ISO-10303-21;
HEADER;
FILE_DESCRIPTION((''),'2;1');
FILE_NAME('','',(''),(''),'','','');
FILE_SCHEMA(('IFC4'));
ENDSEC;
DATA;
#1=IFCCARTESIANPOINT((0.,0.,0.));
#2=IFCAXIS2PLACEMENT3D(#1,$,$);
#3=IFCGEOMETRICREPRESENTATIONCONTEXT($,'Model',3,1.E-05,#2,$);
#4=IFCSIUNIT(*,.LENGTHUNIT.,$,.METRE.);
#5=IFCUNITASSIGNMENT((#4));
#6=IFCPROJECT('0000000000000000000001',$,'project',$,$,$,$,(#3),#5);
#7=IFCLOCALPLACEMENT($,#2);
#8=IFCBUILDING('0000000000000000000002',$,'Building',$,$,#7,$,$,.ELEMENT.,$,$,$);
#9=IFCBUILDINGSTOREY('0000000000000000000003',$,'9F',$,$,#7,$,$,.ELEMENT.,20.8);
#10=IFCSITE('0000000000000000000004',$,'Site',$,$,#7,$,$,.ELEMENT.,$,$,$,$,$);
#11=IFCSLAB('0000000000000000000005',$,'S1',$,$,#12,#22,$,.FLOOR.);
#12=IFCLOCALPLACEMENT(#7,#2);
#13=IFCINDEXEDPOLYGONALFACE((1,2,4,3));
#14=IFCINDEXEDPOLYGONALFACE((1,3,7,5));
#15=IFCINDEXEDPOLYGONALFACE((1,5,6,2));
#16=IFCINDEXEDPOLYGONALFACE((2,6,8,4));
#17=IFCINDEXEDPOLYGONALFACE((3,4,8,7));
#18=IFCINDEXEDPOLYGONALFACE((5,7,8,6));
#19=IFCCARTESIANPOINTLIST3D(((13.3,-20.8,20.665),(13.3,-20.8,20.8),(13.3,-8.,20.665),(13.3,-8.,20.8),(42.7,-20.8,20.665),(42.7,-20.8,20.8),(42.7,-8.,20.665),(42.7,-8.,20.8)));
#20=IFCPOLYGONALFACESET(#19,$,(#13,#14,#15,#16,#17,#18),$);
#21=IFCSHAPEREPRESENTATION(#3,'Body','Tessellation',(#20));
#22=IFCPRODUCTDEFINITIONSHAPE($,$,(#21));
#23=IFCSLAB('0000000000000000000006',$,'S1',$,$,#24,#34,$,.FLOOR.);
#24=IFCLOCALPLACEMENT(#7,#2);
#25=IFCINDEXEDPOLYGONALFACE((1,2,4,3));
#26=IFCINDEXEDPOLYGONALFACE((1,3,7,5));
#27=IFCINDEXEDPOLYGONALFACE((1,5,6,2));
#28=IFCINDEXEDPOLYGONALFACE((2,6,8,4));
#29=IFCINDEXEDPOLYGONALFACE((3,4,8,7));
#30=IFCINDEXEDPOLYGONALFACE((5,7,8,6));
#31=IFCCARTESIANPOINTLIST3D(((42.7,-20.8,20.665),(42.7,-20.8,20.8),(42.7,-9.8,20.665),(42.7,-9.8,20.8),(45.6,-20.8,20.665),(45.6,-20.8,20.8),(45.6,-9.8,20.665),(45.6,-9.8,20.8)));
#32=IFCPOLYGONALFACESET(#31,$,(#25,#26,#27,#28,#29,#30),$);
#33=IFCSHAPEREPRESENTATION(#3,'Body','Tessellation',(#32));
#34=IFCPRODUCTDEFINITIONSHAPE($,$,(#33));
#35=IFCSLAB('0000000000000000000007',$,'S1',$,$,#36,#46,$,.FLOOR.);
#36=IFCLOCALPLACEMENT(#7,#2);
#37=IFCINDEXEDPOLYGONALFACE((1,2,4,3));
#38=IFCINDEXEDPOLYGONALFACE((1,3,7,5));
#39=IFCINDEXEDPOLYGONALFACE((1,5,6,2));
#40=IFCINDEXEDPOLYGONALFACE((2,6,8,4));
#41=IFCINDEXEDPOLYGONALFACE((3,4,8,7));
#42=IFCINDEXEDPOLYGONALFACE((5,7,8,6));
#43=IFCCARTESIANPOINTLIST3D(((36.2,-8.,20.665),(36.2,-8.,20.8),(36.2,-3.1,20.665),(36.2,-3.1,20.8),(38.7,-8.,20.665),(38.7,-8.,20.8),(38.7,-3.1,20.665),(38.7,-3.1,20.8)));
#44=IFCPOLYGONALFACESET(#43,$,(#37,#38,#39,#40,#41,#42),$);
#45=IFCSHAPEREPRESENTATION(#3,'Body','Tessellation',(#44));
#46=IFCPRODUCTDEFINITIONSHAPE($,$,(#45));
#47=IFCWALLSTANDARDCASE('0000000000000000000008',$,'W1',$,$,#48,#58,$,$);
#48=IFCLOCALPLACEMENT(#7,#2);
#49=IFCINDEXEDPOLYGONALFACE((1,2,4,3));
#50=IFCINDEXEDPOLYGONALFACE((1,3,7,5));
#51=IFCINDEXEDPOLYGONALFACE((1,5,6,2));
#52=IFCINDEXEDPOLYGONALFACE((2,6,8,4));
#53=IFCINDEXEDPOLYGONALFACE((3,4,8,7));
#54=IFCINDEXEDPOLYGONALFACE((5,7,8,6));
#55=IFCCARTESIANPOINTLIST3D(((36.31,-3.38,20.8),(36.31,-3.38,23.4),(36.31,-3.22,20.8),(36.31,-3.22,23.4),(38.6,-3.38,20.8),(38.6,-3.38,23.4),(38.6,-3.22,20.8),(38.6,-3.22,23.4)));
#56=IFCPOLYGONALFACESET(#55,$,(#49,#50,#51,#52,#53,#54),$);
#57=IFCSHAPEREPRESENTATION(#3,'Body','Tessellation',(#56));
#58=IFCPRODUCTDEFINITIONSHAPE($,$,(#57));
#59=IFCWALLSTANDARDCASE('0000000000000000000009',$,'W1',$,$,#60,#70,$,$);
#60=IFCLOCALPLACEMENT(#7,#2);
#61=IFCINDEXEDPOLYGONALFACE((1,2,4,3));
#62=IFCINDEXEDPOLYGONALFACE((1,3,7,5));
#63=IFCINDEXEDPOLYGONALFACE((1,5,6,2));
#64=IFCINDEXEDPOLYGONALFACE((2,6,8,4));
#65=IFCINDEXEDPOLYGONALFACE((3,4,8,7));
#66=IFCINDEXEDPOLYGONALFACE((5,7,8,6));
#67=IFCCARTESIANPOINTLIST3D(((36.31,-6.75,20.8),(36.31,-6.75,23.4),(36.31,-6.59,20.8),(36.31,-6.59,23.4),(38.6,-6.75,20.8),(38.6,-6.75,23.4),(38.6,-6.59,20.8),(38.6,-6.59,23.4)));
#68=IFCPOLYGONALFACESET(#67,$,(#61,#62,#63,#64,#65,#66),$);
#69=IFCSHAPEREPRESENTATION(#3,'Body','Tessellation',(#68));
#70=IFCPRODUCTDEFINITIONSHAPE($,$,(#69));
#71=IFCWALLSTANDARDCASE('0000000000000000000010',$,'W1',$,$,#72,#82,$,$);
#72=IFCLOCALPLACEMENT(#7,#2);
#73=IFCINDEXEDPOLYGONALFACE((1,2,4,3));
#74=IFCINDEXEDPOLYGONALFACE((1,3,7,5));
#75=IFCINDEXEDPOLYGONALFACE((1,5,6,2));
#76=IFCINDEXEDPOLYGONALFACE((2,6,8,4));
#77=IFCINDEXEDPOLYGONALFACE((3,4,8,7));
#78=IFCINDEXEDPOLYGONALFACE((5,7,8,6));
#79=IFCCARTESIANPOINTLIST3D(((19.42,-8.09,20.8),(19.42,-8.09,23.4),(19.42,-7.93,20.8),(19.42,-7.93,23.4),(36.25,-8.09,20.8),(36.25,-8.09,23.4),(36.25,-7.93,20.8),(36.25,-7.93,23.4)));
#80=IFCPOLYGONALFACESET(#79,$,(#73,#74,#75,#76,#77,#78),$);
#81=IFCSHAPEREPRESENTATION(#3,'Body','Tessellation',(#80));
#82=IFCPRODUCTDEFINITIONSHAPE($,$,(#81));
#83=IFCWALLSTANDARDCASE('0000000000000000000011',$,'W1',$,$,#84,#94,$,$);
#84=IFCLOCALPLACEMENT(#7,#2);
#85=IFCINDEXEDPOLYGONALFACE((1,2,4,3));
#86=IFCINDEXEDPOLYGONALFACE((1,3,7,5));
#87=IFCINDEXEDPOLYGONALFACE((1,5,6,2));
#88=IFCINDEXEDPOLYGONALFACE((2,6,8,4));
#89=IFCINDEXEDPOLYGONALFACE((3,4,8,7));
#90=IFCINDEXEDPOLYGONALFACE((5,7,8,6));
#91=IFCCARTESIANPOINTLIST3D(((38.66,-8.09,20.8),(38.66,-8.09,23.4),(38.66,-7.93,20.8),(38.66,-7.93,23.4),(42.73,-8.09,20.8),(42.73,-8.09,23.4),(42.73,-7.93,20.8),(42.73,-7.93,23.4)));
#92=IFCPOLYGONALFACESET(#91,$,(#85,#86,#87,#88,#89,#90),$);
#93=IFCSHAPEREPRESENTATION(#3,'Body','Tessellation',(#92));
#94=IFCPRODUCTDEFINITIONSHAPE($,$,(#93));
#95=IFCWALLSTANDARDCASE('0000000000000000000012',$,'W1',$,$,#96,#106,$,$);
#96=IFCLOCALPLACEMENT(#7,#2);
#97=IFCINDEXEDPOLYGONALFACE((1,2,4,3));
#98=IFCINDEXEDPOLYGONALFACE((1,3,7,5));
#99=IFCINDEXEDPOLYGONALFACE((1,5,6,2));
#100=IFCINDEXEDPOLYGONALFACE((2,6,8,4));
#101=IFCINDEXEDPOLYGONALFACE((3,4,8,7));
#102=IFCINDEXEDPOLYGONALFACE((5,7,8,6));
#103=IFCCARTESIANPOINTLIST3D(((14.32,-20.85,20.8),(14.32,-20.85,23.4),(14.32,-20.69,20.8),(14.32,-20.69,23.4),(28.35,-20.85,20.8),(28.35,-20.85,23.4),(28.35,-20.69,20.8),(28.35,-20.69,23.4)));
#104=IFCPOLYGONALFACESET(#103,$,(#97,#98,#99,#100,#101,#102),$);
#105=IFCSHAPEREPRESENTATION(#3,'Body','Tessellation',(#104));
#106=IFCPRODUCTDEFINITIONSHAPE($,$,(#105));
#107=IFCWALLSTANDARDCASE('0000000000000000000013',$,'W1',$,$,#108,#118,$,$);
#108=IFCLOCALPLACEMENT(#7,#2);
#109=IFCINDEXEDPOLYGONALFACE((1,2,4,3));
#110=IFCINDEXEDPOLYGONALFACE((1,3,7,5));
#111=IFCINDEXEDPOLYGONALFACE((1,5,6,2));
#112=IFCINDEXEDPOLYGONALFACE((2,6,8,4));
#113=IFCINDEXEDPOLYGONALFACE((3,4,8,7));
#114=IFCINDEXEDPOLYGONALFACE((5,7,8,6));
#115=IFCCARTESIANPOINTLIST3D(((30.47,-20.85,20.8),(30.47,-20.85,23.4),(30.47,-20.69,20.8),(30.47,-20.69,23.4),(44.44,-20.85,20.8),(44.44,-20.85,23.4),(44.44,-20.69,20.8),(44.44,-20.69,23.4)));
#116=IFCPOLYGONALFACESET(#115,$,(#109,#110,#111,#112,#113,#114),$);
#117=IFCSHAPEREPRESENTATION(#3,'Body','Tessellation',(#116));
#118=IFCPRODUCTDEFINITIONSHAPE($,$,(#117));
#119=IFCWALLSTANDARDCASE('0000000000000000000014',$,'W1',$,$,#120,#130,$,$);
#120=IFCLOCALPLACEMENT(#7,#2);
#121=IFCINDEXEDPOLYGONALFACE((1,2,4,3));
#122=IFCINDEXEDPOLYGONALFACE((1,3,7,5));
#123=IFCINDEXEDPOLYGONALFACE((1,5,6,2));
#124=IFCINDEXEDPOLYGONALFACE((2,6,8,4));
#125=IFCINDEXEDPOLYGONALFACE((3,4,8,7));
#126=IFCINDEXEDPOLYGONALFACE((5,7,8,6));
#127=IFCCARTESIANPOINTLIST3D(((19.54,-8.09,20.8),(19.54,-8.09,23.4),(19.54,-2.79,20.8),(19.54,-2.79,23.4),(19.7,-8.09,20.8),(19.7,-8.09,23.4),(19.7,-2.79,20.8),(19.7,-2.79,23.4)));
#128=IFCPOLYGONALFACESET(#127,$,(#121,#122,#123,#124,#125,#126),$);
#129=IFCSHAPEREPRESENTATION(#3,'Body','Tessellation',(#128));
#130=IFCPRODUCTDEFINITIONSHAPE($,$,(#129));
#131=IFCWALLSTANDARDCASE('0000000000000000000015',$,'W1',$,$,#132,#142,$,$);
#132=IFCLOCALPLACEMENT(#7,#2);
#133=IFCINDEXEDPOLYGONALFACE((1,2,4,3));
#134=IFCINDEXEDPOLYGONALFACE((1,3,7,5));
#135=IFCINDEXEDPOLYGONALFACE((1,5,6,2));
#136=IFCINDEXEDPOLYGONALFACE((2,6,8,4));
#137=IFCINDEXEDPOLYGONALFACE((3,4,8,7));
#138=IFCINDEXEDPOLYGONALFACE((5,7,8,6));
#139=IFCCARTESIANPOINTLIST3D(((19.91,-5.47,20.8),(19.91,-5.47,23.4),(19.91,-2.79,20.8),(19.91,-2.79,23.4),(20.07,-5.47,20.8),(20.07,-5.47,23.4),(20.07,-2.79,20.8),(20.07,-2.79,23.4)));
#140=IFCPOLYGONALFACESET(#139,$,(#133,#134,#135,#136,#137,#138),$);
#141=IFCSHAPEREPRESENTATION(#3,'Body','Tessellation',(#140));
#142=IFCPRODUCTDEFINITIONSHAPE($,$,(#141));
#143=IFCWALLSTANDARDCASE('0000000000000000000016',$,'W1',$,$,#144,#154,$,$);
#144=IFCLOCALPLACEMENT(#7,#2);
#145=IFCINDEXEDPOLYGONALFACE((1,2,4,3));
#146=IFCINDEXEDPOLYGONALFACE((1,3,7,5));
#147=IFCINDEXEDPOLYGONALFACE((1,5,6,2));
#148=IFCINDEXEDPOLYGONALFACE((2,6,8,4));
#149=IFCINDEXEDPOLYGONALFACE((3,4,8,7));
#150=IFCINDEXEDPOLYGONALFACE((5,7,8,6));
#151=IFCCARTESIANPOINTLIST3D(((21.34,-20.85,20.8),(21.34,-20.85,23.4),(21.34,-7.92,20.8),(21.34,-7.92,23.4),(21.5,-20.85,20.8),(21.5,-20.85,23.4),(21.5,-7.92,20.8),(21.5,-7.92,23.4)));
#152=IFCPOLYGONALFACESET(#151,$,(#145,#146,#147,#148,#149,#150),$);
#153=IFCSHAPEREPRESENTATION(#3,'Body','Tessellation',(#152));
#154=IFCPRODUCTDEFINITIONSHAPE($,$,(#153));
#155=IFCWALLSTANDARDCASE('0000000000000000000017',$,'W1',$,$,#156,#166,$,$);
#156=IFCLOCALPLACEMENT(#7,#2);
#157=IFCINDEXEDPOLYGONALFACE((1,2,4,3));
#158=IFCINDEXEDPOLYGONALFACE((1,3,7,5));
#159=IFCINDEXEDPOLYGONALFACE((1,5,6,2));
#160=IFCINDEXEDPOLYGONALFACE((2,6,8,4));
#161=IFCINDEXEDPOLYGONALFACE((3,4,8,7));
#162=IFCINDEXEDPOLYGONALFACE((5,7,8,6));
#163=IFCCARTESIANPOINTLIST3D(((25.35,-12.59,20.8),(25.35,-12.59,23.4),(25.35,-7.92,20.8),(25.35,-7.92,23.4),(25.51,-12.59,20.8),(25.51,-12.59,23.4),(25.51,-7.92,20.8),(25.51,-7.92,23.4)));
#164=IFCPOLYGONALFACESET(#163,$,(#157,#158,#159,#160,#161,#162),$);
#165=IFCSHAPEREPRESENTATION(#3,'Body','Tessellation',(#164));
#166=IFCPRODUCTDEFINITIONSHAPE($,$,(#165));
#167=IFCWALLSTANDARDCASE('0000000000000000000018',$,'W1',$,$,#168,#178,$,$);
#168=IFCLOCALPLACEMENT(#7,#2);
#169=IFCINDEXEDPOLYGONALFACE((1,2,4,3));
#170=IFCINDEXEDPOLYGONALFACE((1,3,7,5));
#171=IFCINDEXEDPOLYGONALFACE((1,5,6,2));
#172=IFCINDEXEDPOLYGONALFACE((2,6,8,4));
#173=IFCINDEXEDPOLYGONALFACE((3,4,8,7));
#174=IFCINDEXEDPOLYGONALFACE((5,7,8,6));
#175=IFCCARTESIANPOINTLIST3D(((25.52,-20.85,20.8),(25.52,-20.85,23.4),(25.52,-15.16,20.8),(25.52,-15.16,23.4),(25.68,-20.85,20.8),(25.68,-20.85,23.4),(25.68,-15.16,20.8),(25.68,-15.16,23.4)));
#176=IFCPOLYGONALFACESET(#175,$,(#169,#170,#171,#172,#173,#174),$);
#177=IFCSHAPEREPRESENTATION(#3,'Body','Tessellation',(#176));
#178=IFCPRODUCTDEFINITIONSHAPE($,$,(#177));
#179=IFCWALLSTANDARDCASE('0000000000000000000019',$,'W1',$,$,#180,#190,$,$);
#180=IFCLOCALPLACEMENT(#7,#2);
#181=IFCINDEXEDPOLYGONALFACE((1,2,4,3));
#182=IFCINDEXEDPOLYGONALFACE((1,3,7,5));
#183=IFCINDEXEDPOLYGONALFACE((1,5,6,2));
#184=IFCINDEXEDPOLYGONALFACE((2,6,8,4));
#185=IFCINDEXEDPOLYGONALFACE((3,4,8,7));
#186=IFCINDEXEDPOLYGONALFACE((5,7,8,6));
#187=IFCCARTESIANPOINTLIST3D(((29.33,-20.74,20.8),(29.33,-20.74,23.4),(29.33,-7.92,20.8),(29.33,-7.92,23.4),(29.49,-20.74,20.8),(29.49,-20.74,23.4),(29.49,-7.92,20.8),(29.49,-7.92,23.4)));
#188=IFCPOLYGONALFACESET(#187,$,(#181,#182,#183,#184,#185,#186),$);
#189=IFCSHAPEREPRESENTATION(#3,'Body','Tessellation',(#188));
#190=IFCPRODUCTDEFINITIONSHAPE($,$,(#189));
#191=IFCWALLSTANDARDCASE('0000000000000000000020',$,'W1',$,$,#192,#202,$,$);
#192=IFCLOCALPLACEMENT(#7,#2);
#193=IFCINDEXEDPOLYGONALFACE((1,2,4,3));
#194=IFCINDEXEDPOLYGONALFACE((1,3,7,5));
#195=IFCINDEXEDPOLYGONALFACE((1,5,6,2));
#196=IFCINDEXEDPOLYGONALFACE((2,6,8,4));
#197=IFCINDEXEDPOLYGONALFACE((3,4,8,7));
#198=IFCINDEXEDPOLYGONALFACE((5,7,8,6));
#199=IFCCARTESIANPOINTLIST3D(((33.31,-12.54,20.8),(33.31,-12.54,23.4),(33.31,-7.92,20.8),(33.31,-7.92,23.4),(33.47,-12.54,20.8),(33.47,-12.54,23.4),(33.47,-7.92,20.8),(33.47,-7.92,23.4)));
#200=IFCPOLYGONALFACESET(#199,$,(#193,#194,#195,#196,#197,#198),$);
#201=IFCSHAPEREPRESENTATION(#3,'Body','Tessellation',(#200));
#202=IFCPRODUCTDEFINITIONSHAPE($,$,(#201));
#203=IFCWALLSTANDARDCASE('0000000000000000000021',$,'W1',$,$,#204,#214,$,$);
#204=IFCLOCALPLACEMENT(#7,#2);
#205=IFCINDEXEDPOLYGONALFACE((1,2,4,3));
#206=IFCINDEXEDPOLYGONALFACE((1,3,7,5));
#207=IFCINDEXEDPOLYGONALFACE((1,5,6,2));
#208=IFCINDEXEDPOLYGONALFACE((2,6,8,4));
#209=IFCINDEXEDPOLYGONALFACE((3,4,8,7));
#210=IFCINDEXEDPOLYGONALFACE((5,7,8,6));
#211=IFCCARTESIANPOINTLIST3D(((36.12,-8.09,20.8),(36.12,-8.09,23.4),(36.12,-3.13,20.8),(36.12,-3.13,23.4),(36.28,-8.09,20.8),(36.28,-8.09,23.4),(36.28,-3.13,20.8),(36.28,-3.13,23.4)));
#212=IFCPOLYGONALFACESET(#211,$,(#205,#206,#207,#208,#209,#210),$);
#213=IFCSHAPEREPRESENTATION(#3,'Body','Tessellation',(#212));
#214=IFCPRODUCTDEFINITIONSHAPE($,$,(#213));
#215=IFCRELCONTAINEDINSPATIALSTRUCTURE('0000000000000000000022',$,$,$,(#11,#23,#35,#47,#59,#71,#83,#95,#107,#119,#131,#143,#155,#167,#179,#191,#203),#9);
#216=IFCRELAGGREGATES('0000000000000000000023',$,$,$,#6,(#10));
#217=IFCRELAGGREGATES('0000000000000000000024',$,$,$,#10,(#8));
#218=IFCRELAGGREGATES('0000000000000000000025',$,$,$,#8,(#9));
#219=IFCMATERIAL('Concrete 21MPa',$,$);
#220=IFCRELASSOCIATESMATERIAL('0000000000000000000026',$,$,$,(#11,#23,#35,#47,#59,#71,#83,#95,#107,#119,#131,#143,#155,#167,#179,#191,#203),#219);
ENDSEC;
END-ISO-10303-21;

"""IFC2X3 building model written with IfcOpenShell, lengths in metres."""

from ifc_helpers import new_model, si_unit, frame, origin, origin_2d, place, context, project, spatial, rectangle, extrude, material, element, save


model = new_model("IFC2X3")

# Units and contexts
model_context = context("Model", 3, precision=1e-05, world=origin())
ifc_project = project(units=[si_unit("LENGTHUNIT", "METRE")], contexts=[model_context])

# Site, building, storey
placement = place(None, origin())
site = spatial("IfcSite", under=ifc_project, at=placement, Name="Site", CompositionType="ELEMENT")
building = spatial("IfcBuilding", under=site, at=placement, Name="Building", CompositionType="ELEMENT")
storey = spatial("IfcBuildingStorey", under=building, at=placement, Name="9F", CompositionType="ELEMENT", Elevation=20.8)

# Slabs
ifc_material_1 = material(Name="Concrete 21MPa")
slab_1_placement = place(None, frame((28.0, -14.4, 20.665)))
element("IfcSlab", 1, at=slab_1_placement, inside=storey, material=ifc_material_1, Name="S1", PredefinedType="FLOOR", context=model_context, shape_type="SweptSolid", body=[
    extrude(rectangle(XDim=29.4, YDim=12.8, at=origin_2d()), origin(), (0.0, 0.0, 1.0), 0.135),
])
slab_2_placement = place(None, frame((44.15, -15.3, 20.665)))
element("IfcSlab", 2, at=slab_2_placement, inside=storey, material=ifc_material_1, Name="S1", PredefinedType="FLOOR", context=model_context, shape_type="SweptSolid", body=[
    extrude(rectangle(XDim=2.9, YDim=11.0, at=origin_2d()), origin(), (0.0, 0.0, 1.0), 0.135),
])
slab_3_placement = place(None, frame((37.45, -5.55, 20.665)))
element("IfcSlab", 3, at=slab_3_placement, inside=storey, material=ifc_material_1, Name="S1", PredefinedType="FLOOR", context=model_context, shape_type="SweptSolid", body=[
    extrude(rectangle(XDim=2.5, YDim=4.9, at=origin_2d()), origin(), (0.0, 0.0, 1.0), 0.135),
])

# Walls
for number, where, name in (
    (4, (37.455, -3.3, 20.8), "W1"),
    (5, (37.455, -6.67, 20.8), "W1"),
):
    element("IfcWallStandardCase", number, at=place(None, frame(where)), inside=storey, material=ifc_material_1, Name=name, context=model_context, shape_type="SweptSolid", body=[
        extrude(rectangle(XDim=2.29, YDim=0.16, at=origin_2d()), origin(), (0.0, 0.0, 1.0), 2.6),
    ])
wall_1_placement = place(None, frame((27.835, -8.01, 20.8)))
element("IfcWallStandardCase", 6, at=wall_1_placement, inside=storey, material=ifc_material_1, Name="W1", context=model_context, shape_type="SweptSolid", body=[
    extrude(rectangle(XDim=16.83, YDim=0.16, at=origin_2d()), origin(), (0.0, 0.0, 1.0), 2.6),
])
wall_2_placement = place(None, frame((40.695, -8.01, 20.8)))
element("IfcWallStandardCase", 7, at=wall_2_placement, inside=storey, material=ifc_material_1, Name="W1", context=model_context, shape_type="SweptSolid", body=[
    extrude(rectangle(XDim=4.07, YDim=0.16, at=origin_2d()), origin(), (0.0, 0.0, 1.0), 2.6),
])
wall_3_placement = place(None, frame((21.335, -20.77, 20.8)))
element("IfcWallStandardCase", 8, at=wall_3_placement, inside=storey, material=ifc_material_1, Name="W1", context=model_context, shape_type="SweptSolid", body=[
    extrude(rectangle(XDim=14.03, YDim=0.16, at=origin_2d()), origin(), (0.0, 0.0, 1.0), 2.6),
])
wall_4_placement = place(None, frame((37.455, -20.77, 20.8)))
element("IfcWallStandardCase", 9, at=wall_4_placement, inside=storey, material=ifc_material_1, Name="W1", context=model_context, shape_type="SweptSolid", body=[
    extrude(rectangle(XDim=13.97, YDim=0.16, at=origin_2d()), origin(), (0.0, 0.0, 1.0), 2.6),
])
wall_5_placement = place(None, frame((19.62, -5.44, 20.8)))
element("IfcWallStandardCase", 10, at=wall_5_placement, inside=storey, material=ifc_material_1, Name="W1", context=model_context, shape_type="SweptSolid", body=[
    extrude(rectangle(XDim=0.16, YDim=5.3, at=origin_2d()), origin(), (0.0, 0.0, 1.0), 2.6),
])
wall_6_placement = place(None, frame((19.99, -4.13, 20.8)))
element("IfcWallStandardCase", 11, at=wall_6_placement, inside=storey, material=ifc_material_1, Name="W1", context=model_context, shape_type="SweptSolid", body=[
    extrude(rectangle(XDim=0.16, YDim=2.68, at=origin_2d()), origin(), (0.0, 0.0, 1.0), 2.6),
])
wall_7_placement = place(None, frame((21.42, -14.385, 20.8)))
element("IfcWallStandardCase", 12, at=wall_7_placement, inside=storey, material=ifc_material_1, Name="W1", context=model_context, shape_type="SweptSolid", body=[
    extrude(rectangle(XDim=0.16, YDim=12.93, at=origin_2d()), origin(), (0.0, 0.0, 1.0), 2.6),
])
wall_8_placement = place(None, frame((25.43, -10.255, 20.8)))
element("IfcWallStandardCase", 13, at=wall_8_placement, inside=storey, material=ifc_material_1, Name="W1", context=model_context, shape_type="SweptSolid", body=[
    extrude(rectangle(XDim=0.16, YDim=4.67, at=origin_2d()), origin(), (0.0, 0.0, 1.0), 2.6),
])
wall_9_placement = place(None, frame((25.6, -18.005, 20.8)))
element("IfcWallStandardCase", 14, at=wall_9_placement, inside=storey, material=ifc_material_1, Name="W1", context=model_context, shape_type="SweptSolid", body=[
    extrude(rectangle(XDim=0.16, YDim=5.69, at=origin_2d()), origin(), (0.0, 0.0, 1.0), 2.6),
])
wall_10_placement = place(None, frame((29.41, -14.33, 20.8)))
element("IfcWallStandardCase", 15, at=wall_10_placement, inside=storey, material=ifc_material_1, Name="W1", context=model_context, shape_type="SweptSolid", body=[
    extrude(rectangle(XDim=0.16, YDim=12.82, at=origin_2d()), origin(), (0.0, 0.0, 1.0), 2.6),
])
wall_11_placement = place(None, frame((33.39, -10.23, 20.8)))
element("IfcWallStandardCase", 16, at=wall_11_placement, inside=storey, material=ifc_material_1, Name="W1", context=model_context, shape_type="SweptSolid", body=[
    extrude(rectangle(XDim=0.16, YDim=4.62, at=origin_2d()), origin(), (0.0, 0.0, 1.0), 2.6),
])
wall_12_placement = place(None, frame((36.2, -5.61, 20.8)))
element("IfcWallStandardCase", 17, at=wall_12_placement, inside=storey, material=ifc_material_1, Name="W1", context=model_context, shape_type="SweptSolid", body=[
    extrude(rectangle(XDim=0.16, YDim=4.96, at=origin_2d()), origin(), (0.0, 0.0, 1.0), 2.6),
])

save(model, "model.ifc")
